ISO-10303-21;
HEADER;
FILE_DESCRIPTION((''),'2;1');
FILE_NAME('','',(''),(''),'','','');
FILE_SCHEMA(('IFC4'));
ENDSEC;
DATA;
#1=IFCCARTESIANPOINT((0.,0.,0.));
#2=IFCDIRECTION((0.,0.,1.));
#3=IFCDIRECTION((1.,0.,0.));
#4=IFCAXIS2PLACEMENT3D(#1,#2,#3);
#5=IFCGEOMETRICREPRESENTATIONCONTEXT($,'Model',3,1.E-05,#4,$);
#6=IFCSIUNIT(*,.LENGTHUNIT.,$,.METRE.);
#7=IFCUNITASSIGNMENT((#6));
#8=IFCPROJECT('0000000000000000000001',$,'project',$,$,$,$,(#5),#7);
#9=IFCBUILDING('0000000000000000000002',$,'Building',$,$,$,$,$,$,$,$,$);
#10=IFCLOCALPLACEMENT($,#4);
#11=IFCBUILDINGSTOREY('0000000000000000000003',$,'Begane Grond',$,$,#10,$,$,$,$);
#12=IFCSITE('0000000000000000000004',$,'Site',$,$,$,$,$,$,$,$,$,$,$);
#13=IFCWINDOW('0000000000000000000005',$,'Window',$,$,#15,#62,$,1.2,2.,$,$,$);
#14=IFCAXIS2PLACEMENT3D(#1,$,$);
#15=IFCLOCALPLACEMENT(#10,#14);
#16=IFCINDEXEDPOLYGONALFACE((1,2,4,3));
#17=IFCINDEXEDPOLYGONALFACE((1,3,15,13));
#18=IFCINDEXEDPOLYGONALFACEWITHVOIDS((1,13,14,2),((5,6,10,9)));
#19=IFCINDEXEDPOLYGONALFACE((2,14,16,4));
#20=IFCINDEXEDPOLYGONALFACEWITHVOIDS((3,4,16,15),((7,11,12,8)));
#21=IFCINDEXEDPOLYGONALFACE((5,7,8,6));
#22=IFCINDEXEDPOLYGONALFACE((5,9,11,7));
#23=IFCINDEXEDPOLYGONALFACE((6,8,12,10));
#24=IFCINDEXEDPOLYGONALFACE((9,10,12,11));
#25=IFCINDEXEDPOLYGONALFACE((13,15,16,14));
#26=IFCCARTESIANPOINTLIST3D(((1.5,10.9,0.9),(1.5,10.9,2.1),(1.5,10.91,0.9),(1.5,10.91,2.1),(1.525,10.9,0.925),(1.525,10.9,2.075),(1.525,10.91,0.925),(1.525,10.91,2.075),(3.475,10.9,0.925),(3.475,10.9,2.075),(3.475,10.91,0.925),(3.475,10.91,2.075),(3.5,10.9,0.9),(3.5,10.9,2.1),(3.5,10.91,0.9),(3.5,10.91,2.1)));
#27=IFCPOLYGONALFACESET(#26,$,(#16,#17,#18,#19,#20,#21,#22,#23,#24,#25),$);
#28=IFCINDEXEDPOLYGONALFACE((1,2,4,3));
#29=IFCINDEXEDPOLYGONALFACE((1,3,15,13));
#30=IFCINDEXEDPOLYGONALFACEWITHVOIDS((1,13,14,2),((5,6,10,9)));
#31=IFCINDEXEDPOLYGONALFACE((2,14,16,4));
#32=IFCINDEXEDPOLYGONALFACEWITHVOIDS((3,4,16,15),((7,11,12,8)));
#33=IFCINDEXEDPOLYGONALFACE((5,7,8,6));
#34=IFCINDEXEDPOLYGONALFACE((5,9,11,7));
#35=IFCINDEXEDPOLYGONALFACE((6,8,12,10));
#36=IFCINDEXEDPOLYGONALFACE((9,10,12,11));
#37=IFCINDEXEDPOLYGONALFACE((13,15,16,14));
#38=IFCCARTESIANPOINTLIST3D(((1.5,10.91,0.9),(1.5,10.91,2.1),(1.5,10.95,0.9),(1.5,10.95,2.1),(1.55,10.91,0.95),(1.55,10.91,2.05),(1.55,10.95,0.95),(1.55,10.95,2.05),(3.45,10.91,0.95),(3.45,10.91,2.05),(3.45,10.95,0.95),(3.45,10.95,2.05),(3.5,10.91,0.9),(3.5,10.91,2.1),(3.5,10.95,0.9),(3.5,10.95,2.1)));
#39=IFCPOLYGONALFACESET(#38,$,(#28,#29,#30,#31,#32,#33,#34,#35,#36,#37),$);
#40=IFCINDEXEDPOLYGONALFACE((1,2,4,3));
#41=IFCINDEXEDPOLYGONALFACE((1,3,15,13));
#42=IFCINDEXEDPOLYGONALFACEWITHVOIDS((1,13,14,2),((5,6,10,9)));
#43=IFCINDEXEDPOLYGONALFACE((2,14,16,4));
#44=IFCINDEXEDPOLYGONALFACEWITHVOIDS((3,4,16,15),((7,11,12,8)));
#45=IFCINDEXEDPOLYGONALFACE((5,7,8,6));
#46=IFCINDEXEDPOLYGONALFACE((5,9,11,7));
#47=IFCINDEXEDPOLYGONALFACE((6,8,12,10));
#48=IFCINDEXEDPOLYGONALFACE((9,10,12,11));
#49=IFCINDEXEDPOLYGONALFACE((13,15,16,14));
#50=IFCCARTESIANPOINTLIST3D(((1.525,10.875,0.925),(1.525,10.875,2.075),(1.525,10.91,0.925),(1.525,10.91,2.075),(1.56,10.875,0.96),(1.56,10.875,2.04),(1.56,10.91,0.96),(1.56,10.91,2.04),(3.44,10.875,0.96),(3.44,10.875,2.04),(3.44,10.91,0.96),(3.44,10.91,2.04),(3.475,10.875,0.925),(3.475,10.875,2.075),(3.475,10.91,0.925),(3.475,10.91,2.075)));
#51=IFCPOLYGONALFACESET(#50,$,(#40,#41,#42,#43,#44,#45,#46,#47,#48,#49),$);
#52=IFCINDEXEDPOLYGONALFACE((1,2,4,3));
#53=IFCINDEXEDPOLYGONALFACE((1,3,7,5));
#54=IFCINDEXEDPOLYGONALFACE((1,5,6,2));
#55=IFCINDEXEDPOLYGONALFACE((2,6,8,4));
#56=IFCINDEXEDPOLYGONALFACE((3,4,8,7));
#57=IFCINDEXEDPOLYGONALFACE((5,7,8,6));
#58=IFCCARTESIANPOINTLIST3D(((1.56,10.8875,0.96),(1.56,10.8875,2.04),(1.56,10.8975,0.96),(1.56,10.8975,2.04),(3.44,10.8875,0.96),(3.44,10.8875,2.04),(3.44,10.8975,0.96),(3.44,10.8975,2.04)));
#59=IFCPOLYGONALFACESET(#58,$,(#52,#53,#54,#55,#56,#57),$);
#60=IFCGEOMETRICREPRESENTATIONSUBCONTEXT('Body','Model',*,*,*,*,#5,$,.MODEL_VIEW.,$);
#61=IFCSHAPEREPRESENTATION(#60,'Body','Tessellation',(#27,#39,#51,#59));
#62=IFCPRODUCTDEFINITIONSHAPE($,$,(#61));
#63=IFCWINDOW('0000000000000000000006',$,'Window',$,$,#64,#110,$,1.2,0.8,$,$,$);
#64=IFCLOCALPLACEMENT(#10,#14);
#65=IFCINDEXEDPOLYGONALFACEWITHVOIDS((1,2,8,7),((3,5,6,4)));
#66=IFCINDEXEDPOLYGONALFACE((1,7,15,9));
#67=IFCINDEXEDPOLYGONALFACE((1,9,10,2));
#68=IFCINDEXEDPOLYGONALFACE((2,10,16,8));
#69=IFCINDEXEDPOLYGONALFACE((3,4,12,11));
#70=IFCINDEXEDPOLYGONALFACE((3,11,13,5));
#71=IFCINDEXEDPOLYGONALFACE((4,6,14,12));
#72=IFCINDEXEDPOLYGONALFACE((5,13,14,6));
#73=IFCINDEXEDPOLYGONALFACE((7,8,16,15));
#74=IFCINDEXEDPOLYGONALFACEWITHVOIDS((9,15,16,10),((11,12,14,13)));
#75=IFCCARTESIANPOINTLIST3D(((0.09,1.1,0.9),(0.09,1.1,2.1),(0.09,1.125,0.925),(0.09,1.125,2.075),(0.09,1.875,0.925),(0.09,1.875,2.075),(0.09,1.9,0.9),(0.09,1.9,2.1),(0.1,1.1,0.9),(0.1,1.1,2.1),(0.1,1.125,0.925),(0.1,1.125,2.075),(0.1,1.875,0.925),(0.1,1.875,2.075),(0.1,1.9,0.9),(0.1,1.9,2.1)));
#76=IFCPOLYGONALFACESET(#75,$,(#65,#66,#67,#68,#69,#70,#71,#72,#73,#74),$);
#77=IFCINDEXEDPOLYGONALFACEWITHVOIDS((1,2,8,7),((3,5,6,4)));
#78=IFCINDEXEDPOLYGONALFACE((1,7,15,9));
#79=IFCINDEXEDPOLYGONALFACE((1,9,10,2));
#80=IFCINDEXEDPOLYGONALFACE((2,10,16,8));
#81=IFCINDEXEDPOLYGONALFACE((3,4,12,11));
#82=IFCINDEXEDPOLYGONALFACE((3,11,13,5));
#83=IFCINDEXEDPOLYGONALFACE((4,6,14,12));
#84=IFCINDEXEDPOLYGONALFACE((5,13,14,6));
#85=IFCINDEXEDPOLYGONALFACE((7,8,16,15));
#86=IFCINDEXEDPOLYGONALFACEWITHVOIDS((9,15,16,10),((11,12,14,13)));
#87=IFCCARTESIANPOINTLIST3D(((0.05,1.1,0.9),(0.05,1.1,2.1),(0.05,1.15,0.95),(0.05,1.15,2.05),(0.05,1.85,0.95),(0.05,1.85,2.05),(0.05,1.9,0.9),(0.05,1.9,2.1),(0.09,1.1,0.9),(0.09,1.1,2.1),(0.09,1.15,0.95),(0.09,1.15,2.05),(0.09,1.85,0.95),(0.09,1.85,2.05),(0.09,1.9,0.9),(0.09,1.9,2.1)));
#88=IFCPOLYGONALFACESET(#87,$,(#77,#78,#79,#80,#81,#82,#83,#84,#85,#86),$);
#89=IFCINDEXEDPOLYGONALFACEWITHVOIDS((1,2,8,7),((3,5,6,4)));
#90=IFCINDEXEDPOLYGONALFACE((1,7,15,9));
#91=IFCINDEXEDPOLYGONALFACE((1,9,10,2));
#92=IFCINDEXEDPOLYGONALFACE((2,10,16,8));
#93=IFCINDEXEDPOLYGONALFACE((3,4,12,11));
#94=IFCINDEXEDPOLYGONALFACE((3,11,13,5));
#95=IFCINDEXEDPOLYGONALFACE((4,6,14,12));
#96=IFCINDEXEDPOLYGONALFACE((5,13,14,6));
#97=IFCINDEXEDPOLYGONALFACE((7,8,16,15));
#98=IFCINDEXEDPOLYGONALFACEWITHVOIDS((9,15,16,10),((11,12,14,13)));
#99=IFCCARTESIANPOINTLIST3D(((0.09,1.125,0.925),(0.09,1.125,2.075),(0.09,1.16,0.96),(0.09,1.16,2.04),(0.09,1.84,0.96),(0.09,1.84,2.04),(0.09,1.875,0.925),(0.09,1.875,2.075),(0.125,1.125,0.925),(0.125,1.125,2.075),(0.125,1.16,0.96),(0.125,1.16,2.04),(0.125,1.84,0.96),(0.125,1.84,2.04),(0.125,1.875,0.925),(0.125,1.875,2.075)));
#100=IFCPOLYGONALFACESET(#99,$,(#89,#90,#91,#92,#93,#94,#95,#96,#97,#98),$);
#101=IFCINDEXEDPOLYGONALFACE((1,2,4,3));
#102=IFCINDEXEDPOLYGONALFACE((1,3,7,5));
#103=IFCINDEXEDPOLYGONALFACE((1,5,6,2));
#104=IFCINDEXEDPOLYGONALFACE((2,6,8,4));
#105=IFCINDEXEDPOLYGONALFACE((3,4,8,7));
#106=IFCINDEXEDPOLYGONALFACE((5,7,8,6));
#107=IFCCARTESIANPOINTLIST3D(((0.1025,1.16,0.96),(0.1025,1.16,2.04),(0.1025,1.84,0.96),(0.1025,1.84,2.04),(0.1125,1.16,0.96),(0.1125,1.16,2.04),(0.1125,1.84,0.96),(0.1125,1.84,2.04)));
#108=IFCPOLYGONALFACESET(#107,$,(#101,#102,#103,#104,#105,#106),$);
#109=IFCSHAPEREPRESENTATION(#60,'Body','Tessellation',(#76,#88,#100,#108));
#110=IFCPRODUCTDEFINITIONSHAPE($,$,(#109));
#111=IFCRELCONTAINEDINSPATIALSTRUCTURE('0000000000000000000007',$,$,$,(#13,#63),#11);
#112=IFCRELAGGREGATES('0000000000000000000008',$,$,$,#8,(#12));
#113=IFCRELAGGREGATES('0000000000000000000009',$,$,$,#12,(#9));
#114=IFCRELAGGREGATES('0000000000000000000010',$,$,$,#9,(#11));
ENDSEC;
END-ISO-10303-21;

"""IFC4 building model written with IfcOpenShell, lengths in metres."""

from ifc_helpers import new_model, si_unit, frame, origin_with_axes, place, context, subcontext, project, spatial, line, indexed_curve, outline, extrude, element, save


model = new_model("IFC4")

# Units and contexts
model_context = context("Model", 3, precision=1e-05, world=origin_with_axes())
body_context = subcontext(model_context, "Body", "Model", "MODEL_VIEW")
ifc_project = project(units=[si_unit("LENGTHUNIT", "METRE")], contexts=[model_context])

# Site, building, storey
site = spatial("IfcSite", under=ifc_project, Name="Site")
building = spatial("IfcBuilding", under=site, Name="Building")
storey_placement = place(None, origin_with_axes())
storey = spatial("IfcBuildingStorey", under=building, at=storey_placement, Name="Begane Grond")

# Windows
window_1_placement = place(storey_placement, frame((3.5, 11.0, 0.9), z_axis=(0.0, 0.0, 1.0), x_axis=(-1.0, 0.0, 0.0)))
element("IfcWindow", 1, at=window_1_placement, inside=storey, Name="Window", OverallHeight=1.2, OverallWidth=2.0, context=body_context, shape_type="SweptSolid", body=[
    extrude(outline(indexed_curve([(0.0, 0.0), (2.0, 0.0), (2.0, 1.2), (0.0, 1.2)], segments=[line(1, 2, 3, 4, 1)]), holes=[indexed_curve([(0.025, 0.025), (1.975, 0.025), (1.975, 1.175), (0.025, 1.175)], segments=[line(1, 2, 3, 4, 1)])]), frame((0.0, 0.09, 0.0), z_axis=(0.0, -1.0, 0.0), x_axis=(1.0, 0.0, 0.0)), (0.0, 0.0, -1.0), 0.01),
    extrude(outline(indexed_curve([(0.0, 0.0), (2.0, 0.0), (2.0, 1.2), (0.0, 1.2)], segments=[line(1, 2, 3, 4, 1)]), holes=[indexed_curve([(0.05, 0.05), (1.95, 0.05), (1.95, 1.15), (0.05, 1.15)], segments=[line(1, 2, 3, 4, 1)])]), frame((0.0, 0.05, 0.0), z_axis=(0.0, -1.0, 0.0), x_axis=(1.0, 0.0, 0.0)), (0.0, 0.0, -1.0), 0.04),
    extrude(outline(indexed_curve([(0.0, 0.0), (1.95, 0.0), (1.95, 1.15), (0.0, 1.15)], segments=[line(1, 2, 3, 4, 1)]), holes=[indexed_curve([(0.035, 0.035), (1.915, 0.035), (1.915, 1.115), (0.035, 1.115)], segments=[line(1, 2, 3, 4, 1)])]), frame((0.025, 0.09, 0.025), z_axis=(0.0, -1.0, 0.0), x_axis=(1.0, 0.0, 0.0)), (0.0, 0.0, -1.0), 0.035),
    extrude(outline(indexed_curve([(0.035, 0.035), (1.915, 0.035), (1.915, 1.115), (0.035, 1.115)], segments=[line(1, 2, 3, 4, 1)])), frame((0.025, 0.1025, 0.025), z_axis=(0.0, -1.0, 0.0), x_axis=(1.0, 0.0, 0.0)), (0.0, 0.0, -1.0), 0.01),
])
window_2_placement = place(storey_placement, frame((0.0, 1.9, 0.9), z_axis=(0.0, 0.0, 1.0), x_axis=(0.0, -1.0, 0.0)))
element("IfcWindow", 2, at=window_2_placement, inside=storey, Name="Window", OverallHeight=1.2, OverallWidth=0.8, context=body_context, shape_type="SweptSolid", body=[
    extrude(outline(indexed_curve([(0.0, 0.0), (0.8, 0.0), (0.8, 1.2), (0.0, 1.2)], segments=[line(1, 2, 3, 4, 1)]), holes=[indexed_curve([(0.025, 0.025), (0.775, 0.025), (0.775, 1.175), (0.025, 1.175)], segments=[line(1, 2, 3, 4, 1)])]), frame((0.0, 0.09, 0.0), z_axis=(0.0, -1.0, 0.0), x_axis=(1.0, 0.0, 0.0)), (0.0, 0.0, -1.0), 0.01),
    extrude(outline(indexed_curve([(0.0, 0.0), (0.8, 0.0), (0.8, 1.2), (0.0, 1.2)], segments=[line(1, 2, 3, 4, 1)]), holes=[indexed_curve([(0.05, 0.05), (0.75, 0.05), (0.75, 1.15), (0.05, 1.15)], segments=[line(1, 2, 3, 4, 1)])]), frame((0.0, 0.05, 0.0), z_axis=(0.0, -1.0, 0.0), x_axis=(1.0, 0.0, 0.0)), (0.0, 0.0, -1.0), 0.04),
    extrude(outline(indexed_curve([(0.0, 0.0), (0.75, 0.0), (0.75, 1.15), (0.0, 1.15)], segments=[line(1, 2, 3, 4, 1)]), holes=[indexed_curve([(0.035, 0.035), (0.715, 0.035), (0.715, 1.115), (0.035, 1.115)], segments=[line(1, 2, 3, 4, 1)])]), frame((0.025, 0.09, 0.025), z_axis=(0.0, -1.0, 0.0), x_axis=(1.0, 0.0, 0.0)), (0.0, 0.0, -1.0), 0.035),
    extrude(outline(indexed_curve([(0.035, 0.035), (0.715, 0.035), (0.715, 1.115), (0.035, 1.115)], segments=[line(1, 2, 3, 4, 1)])), frame((0.025, 0.1025, 0.025), z_axis=(0.0, -1.0, 0.0), x_axis=(1.0, 0.0, 0.0)), (0.0, 0.0, -1.0), 0.01),
])

save(model, "model.ifc")
